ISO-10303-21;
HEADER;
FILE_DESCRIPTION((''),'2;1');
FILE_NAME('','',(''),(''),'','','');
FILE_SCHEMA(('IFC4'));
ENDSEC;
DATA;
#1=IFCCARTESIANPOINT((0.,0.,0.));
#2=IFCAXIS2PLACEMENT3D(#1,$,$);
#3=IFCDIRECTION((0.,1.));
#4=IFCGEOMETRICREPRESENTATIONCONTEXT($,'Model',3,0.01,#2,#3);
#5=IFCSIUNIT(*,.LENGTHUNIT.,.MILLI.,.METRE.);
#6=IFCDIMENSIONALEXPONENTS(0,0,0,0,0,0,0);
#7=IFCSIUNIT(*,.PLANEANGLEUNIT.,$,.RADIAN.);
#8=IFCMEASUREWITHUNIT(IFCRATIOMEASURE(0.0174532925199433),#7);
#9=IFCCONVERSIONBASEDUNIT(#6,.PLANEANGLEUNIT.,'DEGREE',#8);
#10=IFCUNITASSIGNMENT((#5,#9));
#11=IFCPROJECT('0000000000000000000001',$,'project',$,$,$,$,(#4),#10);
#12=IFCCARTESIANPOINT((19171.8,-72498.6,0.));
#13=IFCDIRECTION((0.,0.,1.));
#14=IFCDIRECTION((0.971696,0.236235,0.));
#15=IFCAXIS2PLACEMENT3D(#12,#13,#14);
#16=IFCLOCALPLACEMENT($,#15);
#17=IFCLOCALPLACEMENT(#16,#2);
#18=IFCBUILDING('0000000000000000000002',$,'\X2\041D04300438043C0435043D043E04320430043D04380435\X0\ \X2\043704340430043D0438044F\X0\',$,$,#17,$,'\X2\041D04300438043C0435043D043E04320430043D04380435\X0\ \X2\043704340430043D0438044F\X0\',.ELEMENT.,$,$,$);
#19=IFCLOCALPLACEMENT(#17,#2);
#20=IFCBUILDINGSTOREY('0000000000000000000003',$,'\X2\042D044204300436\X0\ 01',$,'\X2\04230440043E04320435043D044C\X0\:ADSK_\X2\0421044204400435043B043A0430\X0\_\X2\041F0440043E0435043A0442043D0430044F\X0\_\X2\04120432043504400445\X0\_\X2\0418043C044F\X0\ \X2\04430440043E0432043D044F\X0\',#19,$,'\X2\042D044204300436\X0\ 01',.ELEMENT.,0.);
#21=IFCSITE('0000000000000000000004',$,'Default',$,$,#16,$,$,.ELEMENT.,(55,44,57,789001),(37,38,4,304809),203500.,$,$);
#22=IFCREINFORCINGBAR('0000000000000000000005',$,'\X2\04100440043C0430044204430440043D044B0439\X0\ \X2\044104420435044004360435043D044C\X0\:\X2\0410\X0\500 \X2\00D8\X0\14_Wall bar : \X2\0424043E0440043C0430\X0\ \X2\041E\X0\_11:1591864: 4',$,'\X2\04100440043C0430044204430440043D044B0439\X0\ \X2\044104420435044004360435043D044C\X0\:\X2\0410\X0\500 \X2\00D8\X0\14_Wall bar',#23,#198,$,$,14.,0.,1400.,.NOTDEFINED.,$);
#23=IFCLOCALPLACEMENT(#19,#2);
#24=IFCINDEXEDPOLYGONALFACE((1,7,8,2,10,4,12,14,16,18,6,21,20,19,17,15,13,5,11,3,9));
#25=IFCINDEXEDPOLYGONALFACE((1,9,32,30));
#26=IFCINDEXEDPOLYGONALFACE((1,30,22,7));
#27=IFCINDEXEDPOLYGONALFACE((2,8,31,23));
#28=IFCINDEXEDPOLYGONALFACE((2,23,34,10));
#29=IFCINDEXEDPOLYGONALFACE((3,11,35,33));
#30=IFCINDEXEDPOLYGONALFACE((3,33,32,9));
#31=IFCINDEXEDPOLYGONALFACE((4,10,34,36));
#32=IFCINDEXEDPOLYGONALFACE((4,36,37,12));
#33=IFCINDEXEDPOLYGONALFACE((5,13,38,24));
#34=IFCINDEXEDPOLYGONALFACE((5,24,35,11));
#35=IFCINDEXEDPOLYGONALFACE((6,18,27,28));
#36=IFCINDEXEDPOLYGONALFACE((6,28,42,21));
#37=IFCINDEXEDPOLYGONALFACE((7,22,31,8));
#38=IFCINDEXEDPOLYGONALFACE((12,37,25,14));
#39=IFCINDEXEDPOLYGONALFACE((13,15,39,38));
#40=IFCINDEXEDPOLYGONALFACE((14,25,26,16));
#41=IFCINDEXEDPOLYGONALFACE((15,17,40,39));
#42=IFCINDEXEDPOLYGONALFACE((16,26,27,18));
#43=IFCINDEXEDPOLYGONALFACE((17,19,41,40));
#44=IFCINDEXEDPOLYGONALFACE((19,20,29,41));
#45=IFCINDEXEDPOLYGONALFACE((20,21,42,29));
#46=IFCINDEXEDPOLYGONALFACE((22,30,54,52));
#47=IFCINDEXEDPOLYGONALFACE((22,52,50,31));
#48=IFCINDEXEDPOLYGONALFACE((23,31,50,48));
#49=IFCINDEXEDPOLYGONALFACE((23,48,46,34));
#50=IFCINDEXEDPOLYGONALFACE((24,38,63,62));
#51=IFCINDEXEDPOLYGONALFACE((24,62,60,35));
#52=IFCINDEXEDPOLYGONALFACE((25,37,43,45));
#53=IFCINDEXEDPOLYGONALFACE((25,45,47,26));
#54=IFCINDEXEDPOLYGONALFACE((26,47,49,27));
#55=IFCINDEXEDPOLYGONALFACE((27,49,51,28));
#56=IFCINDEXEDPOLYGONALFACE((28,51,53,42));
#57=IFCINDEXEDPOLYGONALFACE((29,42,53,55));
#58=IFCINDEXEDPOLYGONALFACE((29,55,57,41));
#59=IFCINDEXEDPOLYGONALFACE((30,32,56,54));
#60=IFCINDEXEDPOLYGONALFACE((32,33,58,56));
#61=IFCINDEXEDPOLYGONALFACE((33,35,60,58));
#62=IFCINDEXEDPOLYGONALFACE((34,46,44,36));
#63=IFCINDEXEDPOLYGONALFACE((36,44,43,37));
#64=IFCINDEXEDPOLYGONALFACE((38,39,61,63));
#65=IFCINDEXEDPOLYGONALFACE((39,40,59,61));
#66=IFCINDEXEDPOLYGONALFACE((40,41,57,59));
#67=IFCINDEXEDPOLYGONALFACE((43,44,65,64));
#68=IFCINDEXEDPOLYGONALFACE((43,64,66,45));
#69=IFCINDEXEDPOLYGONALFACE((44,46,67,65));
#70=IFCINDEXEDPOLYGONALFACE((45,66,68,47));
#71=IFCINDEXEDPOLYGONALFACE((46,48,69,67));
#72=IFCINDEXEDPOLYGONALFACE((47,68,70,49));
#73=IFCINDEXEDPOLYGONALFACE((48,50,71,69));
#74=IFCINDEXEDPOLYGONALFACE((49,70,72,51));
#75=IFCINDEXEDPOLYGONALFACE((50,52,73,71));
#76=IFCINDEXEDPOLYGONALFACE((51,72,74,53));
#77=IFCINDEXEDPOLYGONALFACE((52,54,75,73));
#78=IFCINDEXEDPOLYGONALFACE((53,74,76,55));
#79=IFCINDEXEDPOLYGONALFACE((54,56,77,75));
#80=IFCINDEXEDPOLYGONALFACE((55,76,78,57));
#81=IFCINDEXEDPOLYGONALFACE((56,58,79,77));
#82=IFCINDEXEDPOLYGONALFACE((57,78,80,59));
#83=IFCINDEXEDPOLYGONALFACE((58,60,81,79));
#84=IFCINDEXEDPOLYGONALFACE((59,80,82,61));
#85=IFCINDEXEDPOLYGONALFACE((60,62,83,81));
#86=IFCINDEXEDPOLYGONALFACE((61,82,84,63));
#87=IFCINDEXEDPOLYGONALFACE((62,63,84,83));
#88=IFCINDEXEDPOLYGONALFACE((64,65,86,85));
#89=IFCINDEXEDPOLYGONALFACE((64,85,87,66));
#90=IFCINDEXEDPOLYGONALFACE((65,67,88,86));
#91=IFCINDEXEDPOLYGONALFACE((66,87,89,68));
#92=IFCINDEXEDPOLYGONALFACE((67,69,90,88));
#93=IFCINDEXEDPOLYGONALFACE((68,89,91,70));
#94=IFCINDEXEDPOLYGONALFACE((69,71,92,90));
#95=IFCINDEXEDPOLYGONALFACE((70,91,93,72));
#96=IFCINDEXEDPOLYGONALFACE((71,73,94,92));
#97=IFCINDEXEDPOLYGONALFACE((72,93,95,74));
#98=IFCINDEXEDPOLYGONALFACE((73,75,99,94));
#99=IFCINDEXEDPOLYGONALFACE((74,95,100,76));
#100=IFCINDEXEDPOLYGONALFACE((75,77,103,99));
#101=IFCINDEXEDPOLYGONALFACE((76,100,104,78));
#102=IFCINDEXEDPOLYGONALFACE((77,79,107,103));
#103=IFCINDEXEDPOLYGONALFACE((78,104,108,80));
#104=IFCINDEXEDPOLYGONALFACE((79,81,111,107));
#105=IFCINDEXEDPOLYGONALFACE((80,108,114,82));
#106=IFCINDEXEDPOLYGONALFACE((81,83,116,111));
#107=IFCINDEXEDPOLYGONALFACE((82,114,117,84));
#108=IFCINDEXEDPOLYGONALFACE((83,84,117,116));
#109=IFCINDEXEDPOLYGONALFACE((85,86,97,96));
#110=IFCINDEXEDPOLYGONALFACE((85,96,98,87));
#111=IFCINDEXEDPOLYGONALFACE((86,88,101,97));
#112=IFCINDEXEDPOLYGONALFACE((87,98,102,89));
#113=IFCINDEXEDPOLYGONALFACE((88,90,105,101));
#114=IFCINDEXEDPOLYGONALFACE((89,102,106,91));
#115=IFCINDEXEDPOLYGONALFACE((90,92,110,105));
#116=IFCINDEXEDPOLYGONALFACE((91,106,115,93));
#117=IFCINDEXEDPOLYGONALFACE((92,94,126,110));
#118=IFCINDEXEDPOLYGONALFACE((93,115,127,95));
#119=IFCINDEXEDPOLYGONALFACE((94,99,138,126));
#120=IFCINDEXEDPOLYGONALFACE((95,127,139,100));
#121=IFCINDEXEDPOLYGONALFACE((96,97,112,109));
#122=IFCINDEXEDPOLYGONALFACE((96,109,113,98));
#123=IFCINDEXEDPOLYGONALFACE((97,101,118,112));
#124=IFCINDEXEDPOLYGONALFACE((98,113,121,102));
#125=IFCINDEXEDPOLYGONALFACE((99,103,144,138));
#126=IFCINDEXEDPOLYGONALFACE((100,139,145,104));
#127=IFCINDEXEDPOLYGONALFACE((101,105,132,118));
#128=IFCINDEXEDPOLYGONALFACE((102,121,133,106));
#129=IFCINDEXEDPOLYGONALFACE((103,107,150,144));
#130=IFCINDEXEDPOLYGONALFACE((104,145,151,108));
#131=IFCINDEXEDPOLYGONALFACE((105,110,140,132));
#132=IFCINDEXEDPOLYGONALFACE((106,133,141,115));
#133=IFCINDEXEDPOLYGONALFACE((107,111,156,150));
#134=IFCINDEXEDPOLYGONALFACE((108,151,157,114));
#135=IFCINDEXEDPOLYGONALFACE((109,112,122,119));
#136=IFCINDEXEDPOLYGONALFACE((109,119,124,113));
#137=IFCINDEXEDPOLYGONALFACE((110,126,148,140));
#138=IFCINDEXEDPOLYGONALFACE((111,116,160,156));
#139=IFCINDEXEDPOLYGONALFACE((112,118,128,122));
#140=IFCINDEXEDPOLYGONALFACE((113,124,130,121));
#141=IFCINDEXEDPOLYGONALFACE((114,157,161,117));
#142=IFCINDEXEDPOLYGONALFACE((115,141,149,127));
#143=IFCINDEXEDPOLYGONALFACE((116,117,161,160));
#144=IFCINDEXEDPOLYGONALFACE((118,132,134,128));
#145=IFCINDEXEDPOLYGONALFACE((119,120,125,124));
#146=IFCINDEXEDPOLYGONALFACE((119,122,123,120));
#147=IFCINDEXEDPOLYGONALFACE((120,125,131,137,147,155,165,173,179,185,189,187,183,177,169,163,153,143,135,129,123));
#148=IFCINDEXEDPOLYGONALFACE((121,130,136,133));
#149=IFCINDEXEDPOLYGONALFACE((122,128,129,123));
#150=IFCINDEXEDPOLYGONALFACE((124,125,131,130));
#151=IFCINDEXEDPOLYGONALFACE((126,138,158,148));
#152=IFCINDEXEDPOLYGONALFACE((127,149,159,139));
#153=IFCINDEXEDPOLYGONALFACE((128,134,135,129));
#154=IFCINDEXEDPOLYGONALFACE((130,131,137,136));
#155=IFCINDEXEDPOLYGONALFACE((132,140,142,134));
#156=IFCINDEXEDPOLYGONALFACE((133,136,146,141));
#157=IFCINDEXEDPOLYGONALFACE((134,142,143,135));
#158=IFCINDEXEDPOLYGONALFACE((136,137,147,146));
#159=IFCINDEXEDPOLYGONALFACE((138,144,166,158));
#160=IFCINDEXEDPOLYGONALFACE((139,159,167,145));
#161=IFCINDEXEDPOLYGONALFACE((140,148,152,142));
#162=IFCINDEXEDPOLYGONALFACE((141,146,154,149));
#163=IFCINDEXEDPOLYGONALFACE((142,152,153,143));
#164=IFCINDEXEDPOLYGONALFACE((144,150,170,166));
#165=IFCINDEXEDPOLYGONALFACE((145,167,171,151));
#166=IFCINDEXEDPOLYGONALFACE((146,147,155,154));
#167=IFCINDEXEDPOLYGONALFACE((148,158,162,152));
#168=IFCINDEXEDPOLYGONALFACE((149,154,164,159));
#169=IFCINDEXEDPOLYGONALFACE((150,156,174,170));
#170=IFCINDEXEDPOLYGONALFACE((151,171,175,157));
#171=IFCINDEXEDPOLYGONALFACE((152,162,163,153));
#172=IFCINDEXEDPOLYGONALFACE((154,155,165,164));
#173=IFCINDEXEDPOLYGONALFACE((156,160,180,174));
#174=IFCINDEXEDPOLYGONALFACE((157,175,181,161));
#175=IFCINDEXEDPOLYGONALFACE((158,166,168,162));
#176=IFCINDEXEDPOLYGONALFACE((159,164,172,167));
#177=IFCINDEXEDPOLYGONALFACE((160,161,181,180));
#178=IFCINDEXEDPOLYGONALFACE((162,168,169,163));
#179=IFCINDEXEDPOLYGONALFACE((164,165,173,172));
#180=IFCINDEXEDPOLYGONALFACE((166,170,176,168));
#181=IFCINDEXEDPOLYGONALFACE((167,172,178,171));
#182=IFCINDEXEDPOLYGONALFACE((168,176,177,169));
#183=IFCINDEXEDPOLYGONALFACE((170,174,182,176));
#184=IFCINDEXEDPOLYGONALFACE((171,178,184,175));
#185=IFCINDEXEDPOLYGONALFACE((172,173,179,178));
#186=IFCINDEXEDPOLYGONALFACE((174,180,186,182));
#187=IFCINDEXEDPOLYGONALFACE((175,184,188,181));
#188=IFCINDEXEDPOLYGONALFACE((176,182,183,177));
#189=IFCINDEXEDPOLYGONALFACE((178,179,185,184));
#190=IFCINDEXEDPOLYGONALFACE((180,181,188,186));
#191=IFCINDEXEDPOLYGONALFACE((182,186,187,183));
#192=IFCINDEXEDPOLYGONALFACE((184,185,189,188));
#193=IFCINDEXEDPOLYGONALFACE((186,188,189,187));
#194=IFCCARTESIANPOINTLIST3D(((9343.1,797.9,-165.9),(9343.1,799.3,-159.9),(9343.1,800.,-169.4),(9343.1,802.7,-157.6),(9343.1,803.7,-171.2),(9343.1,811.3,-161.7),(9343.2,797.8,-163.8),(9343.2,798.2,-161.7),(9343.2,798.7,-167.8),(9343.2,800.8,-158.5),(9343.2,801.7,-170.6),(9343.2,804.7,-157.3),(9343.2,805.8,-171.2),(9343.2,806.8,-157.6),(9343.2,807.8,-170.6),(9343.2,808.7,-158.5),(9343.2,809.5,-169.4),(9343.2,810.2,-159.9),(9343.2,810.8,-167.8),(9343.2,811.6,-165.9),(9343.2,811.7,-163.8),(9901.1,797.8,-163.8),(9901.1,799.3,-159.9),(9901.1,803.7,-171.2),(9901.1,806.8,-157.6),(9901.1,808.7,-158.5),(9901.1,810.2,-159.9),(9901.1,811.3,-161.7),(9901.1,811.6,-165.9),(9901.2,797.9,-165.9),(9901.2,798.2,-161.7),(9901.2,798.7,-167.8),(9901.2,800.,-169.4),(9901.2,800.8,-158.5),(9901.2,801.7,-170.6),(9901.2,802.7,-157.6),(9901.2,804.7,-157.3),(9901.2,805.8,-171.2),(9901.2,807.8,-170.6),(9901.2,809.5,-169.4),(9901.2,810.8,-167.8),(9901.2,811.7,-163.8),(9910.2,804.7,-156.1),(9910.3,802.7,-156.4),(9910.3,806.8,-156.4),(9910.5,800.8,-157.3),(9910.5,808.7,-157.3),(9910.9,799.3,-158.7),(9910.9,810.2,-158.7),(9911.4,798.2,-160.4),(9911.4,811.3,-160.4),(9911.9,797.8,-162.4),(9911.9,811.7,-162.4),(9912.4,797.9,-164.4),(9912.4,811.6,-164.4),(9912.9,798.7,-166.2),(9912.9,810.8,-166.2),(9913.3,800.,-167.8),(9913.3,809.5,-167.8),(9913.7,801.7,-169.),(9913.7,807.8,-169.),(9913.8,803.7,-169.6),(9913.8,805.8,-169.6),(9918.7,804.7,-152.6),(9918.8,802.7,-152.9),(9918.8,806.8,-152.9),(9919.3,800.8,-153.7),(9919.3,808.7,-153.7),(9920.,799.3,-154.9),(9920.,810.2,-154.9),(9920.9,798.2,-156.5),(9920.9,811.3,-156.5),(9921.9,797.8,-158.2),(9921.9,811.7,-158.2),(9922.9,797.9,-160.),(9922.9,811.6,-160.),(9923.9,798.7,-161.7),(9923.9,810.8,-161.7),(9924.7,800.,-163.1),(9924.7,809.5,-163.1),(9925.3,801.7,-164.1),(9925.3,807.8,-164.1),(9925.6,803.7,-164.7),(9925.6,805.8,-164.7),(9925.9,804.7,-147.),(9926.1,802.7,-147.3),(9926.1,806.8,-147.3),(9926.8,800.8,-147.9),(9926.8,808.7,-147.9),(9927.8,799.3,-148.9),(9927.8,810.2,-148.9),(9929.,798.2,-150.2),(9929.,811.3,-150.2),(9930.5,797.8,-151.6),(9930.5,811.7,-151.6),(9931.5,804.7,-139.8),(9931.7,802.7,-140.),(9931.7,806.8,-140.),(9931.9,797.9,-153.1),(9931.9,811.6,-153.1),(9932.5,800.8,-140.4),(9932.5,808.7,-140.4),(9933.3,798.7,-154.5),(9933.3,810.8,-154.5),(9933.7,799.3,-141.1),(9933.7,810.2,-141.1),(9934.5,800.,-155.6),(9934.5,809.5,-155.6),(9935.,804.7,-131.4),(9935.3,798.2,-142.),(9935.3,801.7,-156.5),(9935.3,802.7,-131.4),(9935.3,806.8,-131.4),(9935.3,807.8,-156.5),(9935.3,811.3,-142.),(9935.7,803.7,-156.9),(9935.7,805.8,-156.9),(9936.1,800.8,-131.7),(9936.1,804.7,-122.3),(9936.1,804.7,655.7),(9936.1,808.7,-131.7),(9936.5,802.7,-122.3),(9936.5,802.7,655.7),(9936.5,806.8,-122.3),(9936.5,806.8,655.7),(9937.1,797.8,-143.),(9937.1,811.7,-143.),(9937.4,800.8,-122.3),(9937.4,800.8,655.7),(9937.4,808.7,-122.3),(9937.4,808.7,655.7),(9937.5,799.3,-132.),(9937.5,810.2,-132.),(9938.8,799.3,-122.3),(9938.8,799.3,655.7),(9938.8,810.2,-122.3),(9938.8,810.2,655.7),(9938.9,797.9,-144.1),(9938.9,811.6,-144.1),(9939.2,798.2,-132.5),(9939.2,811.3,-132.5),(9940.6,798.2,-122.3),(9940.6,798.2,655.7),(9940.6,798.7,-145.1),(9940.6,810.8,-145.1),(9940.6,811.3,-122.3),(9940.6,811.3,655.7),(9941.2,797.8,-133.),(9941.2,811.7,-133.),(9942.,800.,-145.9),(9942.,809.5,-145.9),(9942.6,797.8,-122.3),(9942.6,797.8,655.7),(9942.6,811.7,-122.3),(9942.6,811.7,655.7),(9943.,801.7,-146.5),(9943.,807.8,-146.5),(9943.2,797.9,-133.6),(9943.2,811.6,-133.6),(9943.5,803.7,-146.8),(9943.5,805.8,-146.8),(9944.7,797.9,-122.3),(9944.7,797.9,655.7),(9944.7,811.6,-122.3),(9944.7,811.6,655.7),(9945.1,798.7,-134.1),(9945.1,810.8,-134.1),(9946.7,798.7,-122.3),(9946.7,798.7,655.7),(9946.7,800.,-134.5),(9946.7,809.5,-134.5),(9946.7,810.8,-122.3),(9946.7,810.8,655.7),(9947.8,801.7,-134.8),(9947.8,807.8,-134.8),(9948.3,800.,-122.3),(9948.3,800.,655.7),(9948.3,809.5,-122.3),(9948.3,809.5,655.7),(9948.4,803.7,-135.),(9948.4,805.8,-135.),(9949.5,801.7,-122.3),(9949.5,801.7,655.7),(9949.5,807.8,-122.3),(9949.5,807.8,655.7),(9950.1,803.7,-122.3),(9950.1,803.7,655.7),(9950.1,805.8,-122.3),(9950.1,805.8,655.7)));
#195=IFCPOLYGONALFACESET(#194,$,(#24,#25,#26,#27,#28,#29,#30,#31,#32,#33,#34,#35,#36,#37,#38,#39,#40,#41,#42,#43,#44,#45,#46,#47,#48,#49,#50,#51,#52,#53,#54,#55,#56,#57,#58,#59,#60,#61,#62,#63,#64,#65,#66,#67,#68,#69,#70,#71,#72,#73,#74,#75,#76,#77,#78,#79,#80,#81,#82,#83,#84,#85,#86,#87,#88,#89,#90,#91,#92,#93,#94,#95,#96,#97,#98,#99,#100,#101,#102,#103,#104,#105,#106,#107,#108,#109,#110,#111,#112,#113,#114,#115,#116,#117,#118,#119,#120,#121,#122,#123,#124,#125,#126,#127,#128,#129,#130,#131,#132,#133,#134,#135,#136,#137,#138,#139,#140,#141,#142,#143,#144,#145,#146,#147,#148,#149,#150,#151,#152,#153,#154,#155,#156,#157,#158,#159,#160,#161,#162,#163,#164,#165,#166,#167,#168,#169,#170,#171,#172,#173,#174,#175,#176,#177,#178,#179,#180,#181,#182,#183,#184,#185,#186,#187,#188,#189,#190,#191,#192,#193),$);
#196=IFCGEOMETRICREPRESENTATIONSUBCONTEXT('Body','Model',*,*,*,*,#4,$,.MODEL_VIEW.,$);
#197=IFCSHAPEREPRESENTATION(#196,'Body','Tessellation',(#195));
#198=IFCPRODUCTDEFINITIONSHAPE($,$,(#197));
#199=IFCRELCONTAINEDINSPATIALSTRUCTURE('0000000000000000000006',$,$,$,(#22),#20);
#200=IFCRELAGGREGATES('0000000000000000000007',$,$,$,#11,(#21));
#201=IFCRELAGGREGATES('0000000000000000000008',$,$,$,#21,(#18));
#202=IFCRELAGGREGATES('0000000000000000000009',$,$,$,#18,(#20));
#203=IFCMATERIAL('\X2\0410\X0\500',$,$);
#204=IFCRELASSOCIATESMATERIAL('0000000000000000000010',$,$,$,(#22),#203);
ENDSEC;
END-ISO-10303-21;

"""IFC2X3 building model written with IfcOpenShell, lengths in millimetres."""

from ifc_helpers import new_model, entity, si_unit, converted_unit, direction, frame, origin, place, context, subcontext, project, spatial, material, element, save


model = new_model("IFC2X3")

# Units and contexts
model_context = context("Model", 3, precision=0.01, world=origin(), true_north=direction((0.0, 1.0)))
body_context = subcontext(model_context, "Body", "Model", "MODEL_VIEW")
ifc_project = project(units=[si_unit("LENGTHUNIT", "METRE", prefix="MILLI"), converted_unit("PLANEANGLEUNIT", "DEGREE", entity("IfcRatioMeasure", 0.0174532925199433), si_unit("PLANEANGLEUNIT", "RADIAN"), dimensions=[0, 0, 0, 0, 0, 0, 0])], contexts=[model_context])

# Site, building, storey
site_placement = place(None, frame((19171.8, -72498.6, 0.0), z_axis=(0.0, 0.0, 1.0), x_axis=(0.971696, 0.236235, 0.0)))
site = spatial("IfcSite", under=ifc_project, at=site_placement, Name="Default", CompositionType="ELEMENT", RefLatitude=(55, 44, 57, 789001), RefLongitude=(37, 38, 4, 304809), RefElevation=203500.0)
building_placement = place(site_placement, origin())
building = spatial("IfcBuilding", under=site, at=building_placement, Name="Наименование здания", LongName="Наименование здания", CompositionType="ELEMENT")
storey_placement = place(building_placement, origin())
storey = spatial("IfcBuildingStorey", under=building, at=storey_placement, Name="Этаж 01", ObjectType="Уровень:ADSK_Стрелка_Проектная_Вверх_Имя уровня", LongName="Этаж 01", CompositionType="ELEMENT", Elevation=0.0)

# Reinforcing bar
ifc_material = material(Name="А500")
placement = place(storey_placement, origin())
element("IfcReinforcingBar", 1, at=placement, inside=storey, material=ifc_material, Name="Арматурный стержень:А500 Ø14_Wall bar : Форма О_11:1591864: 4", ObjectType="Арматурный стержень:А500 Ø14_Wall bar", BarLength=1400.0, BarRole="NOTDEFINED", CrossSectionArea=0.0, NominalDiameter=14.0, context=body_context, shape_type="AdvancedSweptSolid", body=[
    entity("IfcSweptDiskSolid", entity("IfcCompositeCurve", [entity("IfcCompositeCurveSegment", "CONTINUOUS", True, entity("IfcPolyline", [entity("IfcCartesianPoint", [9943.1, 804.7, 655.7]), entity("IfcCartesianPoint", [9943.1, 804.7, -122.3])])), entity("IfcCompositeCurveSegment", "CONTINUOUS", True, entity("IfcTrimmedCurve", entity("IfcCircle", entity("IfcAxis2Placement3D", entity("IfcCartesianPoint", [9901.1, 804.7, -122.3]), entity("IfcDirection", [0.0, 1.0, 0.0]), entity("IfcDirection", [0.0, 0.0, -1.0])), 42.0), [entity("IfcParameterValue", 270.0)], [entity("IfcParameterValue", 360.0)], True, "PARAMETER")), entity("IfcCompositeCurveSegment", "CONTINUOUS", True, entity("IfcPolyline", [entity("IfcCartesianPoint", [9901.1, 804.7, -164.3]), entity("IfcCartesianPoint", [9343.1, 804.7, -164.3])]))], False), 7.0, None, 0.0, 92.0),
])

save(model, "model.ifc")
